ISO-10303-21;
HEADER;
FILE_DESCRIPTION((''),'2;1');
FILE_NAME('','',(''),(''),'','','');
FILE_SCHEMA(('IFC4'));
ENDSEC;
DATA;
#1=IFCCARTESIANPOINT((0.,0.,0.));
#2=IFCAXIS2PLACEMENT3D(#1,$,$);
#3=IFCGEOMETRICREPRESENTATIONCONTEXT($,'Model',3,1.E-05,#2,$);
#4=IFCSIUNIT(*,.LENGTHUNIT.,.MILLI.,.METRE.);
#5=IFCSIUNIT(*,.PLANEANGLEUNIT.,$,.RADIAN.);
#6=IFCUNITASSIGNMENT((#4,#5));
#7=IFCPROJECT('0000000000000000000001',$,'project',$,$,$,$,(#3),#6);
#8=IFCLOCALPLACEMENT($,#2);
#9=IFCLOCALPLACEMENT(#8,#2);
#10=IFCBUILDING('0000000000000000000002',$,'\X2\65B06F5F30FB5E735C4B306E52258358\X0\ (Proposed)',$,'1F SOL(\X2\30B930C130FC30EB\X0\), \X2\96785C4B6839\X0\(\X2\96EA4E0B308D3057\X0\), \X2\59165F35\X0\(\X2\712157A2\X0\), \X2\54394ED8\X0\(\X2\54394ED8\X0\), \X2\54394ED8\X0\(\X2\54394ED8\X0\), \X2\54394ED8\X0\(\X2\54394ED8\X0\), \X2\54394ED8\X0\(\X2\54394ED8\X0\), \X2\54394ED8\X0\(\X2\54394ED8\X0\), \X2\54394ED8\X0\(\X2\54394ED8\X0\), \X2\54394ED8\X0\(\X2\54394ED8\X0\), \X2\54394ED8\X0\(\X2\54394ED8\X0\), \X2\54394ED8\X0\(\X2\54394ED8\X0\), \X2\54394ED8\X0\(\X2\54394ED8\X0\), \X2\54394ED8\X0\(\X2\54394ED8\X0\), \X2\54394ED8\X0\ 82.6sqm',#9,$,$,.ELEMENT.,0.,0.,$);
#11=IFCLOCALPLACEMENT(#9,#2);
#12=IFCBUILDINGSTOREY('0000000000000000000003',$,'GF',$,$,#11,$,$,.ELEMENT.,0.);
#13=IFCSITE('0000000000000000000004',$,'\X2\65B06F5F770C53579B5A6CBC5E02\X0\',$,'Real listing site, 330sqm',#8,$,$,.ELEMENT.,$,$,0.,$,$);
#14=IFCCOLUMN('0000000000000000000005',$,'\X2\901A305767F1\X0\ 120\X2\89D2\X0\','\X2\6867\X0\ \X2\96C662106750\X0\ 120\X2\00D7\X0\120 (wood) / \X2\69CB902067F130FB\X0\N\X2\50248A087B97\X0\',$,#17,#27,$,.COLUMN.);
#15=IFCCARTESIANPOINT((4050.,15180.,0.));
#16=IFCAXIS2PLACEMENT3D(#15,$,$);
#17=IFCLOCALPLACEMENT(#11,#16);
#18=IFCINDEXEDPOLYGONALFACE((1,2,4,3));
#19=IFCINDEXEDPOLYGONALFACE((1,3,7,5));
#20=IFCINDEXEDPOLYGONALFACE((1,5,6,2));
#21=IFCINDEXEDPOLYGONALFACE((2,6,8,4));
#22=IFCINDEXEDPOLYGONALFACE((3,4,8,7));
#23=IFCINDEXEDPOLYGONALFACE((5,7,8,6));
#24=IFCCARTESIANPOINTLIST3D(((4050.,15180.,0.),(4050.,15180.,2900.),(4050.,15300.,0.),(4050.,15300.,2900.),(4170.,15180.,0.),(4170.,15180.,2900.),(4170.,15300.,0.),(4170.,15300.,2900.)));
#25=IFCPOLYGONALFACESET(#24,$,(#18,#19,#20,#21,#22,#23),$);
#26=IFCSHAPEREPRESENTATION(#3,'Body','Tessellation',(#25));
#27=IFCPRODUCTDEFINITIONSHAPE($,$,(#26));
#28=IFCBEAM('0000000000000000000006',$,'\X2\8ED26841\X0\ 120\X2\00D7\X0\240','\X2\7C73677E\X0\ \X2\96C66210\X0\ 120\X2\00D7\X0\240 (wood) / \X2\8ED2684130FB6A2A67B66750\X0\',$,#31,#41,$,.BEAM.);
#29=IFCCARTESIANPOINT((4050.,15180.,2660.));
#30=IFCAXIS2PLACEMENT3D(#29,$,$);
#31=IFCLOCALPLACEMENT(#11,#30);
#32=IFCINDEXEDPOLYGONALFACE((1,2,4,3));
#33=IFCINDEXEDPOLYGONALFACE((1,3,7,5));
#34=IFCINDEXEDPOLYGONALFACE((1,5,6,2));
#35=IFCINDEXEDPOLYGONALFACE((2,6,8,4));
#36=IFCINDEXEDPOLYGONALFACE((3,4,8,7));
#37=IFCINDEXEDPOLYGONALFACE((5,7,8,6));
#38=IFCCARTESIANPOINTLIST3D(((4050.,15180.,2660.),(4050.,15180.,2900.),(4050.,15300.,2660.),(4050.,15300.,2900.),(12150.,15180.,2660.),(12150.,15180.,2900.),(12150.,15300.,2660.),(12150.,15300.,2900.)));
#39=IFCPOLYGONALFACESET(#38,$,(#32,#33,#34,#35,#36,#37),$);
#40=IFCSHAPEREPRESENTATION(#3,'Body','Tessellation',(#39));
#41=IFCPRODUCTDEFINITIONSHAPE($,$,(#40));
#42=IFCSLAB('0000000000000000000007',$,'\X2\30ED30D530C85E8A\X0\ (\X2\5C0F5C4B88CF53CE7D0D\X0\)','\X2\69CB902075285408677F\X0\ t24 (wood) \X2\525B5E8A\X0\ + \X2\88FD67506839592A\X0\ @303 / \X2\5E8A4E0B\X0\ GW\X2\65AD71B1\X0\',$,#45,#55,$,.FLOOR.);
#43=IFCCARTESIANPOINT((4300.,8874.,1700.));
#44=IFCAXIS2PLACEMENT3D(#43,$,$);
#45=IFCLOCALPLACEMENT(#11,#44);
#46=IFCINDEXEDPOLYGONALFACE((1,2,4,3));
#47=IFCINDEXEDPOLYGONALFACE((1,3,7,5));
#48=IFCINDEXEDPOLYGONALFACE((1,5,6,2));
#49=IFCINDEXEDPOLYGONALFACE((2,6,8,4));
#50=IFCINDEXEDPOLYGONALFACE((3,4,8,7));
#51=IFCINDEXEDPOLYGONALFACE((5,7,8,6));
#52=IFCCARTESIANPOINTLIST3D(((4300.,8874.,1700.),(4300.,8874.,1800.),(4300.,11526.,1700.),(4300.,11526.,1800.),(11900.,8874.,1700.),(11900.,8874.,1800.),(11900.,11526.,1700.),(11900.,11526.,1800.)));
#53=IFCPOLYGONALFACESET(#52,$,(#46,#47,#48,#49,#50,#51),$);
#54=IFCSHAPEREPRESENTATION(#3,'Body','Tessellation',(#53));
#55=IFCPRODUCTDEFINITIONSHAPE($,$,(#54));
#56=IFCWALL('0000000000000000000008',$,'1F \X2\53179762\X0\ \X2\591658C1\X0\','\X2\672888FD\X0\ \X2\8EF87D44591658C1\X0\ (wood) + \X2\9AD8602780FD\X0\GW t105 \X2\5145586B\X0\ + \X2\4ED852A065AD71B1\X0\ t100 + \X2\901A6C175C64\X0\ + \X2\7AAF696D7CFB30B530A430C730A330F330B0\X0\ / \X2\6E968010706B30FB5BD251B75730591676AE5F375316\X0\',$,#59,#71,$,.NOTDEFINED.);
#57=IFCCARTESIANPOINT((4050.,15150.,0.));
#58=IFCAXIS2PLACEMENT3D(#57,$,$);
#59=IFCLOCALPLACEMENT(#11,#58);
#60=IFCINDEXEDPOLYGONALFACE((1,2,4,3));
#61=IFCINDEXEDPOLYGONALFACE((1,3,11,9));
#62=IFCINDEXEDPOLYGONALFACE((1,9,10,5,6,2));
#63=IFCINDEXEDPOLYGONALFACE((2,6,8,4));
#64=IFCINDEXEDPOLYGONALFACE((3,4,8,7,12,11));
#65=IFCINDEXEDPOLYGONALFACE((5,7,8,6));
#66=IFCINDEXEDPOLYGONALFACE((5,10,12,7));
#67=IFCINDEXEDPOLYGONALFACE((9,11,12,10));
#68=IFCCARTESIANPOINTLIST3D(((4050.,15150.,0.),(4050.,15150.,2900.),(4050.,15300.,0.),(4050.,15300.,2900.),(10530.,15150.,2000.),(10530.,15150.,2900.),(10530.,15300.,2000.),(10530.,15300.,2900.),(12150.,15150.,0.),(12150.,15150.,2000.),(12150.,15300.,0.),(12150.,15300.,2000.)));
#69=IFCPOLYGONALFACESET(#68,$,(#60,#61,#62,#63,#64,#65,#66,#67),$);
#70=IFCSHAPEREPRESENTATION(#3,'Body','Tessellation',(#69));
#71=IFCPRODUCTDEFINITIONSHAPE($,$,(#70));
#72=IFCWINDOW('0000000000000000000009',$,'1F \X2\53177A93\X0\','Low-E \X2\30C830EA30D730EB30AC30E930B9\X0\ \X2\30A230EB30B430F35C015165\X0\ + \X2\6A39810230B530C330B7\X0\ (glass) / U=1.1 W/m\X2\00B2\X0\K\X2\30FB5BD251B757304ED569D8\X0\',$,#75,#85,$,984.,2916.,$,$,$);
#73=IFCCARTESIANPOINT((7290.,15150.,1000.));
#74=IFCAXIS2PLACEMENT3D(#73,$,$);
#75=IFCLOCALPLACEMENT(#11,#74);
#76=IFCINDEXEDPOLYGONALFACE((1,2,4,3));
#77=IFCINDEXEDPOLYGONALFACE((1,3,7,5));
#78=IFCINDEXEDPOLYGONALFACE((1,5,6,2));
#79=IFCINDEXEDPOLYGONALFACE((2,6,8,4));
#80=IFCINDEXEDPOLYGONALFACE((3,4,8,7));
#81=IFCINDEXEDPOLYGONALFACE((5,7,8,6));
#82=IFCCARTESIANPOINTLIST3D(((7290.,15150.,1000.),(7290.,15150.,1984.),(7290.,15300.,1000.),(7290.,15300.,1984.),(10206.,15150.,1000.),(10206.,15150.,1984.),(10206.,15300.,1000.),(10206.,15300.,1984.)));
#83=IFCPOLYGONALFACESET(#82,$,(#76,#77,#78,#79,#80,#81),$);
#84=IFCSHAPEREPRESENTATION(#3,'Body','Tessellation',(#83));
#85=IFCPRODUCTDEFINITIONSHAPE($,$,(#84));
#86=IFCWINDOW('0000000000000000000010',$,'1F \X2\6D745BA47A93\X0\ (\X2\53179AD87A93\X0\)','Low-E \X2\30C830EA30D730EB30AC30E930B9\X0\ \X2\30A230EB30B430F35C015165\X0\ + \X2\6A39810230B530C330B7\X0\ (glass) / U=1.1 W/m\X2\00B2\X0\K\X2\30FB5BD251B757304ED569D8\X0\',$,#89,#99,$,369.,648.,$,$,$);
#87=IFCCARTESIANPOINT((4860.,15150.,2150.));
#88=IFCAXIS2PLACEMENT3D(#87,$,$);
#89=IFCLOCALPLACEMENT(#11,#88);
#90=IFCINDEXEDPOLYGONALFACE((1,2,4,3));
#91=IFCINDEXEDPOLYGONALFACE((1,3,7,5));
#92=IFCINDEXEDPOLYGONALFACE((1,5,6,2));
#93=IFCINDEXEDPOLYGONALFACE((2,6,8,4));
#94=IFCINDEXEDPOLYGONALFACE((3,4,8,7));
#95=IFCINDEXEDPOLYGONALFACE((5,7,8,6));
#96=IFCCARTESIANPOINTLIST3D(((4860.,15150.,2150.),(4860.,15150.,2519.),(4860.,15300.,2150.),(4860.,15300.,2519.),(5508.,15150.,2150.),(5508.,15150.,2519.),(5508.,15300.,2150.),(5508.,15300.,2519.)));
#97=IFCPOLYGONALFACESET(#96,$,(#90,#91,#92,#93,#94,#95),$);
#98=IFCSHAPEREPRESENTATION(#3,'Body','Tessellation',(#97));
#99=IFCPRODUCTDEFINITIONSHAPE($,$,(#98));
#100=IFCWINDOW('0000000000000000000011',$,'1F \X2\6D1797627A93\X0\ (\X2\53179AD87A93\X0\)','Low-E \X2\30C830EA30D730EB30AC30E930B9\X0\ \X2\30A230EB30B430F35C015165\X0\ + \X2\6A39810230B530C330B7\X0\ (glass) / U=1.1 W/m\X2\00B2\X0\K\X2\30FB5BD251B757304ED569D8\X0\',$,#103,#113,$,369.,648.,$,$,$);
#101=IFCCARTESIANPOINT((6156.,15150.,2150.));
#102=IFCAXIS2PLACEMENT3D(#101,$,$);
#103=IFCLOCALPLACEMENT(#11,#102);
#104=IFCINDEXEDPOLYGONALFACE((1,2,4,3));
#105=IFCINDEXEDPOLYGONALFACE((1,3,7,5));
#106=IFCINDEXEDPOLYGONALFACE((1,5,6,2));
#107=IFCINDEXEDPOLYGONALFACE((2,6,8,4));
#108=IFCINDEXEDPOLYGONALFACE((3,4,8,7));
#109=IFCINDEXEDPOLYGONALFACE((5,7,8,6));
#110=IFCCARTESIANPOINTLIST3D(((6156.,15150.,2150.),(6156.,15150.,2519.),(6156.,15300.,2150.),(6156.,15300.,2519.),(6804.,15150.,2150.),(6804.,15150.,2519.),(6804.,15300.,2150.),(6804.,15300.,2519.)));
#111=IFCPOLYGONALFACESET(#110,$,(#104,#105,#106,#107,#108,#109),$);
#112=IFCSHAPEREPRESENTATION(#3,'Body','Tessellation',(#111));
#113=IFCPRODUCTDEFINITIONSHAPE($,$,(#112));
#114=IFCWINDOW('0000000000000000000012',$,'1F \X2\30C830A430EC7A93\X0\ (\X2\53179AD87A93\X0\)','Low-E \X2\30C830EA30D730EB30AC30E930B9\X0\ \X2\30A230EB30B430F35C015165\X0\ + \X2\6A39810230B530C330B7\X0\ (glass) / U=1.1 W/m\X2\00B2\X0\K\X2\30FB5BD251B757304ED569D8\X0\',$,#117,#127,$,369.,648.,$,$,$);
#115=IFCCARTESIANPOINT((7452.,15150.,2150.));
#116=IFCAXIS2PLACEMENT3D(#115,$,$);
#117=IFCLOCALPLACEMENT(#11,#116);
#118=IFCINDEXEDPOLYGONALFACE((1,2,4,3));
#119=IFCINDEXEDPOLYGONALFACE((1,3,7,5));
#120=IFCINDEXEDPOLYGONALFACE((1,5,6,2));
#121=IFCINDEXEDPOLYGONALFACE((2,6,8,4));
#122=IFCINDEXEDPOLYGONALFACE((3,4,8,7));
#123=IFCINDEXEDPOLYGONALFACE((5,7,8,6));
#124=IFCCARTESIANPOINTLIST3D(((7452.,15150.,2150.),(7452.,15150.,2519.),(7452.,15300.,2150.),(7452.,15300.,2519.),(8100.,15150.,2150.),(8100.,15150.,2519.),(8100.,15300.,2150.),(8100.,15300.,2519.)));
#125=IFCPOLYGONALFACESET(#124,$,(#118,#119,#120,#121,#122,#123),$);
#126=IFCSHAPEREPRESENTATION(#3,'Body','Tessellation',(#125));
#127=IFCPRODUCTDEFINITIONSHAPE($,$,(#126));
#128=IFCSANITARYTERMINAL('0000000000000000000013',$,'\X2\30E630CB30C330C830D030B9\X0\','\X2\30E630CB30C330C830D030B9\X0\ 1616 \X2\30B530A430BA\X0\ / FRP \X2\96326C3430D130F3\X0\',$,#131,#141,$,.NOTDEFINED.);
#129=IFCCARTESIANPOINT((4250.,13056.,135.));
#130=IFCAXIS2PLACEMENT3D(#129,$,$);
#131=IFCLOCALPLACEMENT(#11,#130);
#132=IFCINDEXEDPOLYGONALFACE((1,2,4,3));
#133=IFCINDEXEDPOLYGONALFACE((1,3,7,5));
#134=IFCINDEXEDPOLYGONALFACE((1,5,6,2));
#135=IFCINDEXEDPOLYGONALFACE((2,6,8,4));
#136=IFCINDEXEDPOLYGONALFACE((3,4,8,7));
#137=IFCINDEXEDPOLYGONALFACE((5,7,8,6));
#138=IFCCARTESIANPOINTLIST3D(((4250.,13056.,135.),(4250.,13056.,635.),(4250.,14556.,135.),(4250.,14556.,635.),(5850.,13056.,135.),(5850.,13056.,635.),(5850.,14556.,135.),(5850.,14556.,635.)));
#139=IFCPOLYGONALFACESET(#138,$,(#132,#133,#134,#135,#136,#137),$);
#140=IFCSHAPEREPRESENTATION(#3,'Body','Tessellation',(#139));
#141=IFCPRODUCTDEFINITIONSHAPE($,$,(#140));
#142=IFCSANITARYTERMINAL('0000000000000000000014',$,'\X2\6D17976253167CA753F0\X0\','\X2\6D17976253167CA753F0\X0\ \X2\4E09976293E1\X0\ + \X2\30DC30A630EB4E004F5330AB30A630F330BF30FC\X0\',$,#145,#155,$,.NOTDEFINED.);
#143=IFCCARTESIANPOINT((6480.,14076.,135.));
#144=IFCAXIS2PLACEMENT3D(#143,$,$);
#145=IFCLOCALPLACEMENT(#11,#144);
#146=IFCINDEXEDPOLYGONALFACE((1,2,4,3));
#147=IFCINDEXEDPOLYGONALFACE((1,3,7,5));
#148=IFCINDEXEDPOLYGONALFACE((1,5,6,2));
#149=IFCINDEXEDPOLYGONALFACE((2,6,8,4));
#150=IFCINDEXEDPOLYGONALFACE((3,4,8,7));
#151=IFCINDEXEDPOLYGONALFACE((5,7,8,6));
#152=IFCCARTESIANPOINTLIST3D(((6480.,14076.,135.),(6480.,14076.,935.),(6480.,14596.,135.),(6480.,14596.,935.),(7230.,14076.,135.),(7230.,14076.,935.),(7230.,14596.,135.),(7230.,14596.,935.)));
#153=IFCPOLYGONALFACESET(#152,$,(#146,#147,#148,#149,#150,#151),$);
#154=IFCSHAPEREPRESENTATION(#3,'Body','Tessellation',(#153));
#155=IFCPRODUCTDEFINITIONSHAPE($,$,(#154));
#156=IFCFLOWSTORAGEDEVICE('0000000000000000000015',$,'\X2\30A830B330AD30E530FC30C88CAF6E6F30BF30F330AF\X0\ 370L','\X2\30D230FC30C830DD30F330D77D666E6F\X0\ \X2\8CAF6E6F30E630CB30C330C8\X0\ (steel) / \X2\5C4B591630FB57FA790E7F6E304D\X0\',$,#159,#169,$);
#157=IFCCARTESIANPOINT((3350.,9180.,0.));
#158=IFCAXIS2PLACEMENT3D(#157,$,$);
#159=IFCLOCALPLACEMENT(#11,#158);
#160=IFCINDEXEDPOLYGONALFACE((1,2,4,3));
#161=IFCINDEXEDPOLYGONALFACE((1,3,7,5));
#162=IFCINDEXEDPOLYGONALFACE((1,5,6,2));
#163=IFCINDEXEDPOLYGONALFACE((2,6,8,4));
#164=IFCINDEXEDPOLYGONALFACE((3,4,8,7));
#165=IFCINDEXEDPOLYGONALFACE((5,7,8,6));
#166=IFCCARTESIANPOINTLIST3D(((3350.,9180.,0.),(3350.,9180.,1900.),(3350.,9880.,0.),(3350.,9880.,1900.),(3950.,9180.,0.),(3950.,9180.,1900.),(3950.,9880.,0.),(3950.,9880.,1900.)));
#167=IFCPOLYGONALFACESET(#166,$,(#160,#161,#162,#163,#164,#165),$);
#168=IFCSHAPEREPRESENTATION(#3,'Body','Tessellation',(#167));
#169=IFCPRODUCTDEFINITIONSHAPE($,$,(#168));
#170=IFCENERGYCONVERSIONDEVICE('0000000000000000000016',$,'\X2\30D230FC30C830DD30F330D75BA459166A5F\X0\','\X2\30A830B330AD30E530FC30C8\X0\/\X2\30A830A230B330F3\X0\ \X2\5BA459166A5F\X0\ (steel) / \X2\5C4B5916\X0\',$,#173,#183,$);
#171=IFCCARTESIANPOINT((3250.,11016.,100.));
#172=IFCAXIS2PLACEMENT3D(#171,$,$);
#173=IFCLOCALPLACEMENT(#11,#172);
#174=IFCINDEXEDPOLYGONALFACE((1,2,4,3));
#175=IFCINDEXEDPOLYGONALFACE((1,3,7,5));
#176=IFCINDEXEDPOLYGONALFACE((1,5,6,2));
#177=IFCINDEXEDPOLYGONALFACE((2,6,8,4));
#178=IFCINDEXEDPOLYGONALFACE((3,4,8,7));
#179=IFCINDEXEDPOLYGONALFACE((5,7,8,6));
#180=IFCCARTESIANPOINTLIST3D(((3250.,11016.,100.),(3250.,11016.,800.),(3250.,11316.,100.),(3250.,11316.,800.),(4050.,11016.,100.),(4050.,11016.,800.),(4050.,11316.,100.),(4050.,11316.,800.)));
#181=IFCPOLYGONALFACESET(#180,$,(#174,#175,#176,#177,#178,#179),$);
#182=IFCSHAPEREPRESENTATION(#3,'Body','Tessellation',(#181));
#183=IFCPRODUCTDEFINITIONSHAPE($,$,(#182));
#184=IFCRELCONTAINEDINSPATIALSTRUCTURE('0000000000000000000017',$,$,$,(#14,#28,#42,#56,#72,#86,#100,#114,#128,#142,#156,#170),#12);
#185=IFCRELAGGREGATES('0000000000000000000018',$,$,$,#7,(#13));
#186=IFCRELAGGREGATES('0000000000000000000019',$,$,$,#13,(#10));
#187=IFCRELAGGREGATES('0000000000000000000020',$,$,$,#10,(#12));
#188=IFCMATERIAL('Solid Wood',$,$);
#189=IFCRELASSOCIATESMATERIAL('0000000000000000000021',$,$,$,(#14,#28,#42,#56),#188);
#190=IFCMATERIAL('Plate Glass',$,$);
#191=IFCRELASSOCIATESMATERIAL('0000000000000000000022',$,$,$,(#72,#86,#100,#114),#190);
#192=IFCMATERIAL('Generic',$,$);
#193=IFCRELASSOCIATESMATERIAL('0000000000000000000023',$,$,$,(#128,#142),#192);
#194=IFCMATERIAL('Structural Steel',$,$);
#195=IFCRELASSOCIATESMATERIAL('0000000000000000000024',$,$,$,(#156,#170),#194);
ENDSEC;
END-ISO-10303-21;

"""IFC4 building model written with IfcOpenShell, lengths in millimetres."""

from ifc_helpers import new_model, si_unit, frame, frame_2d, origin, place, context, project, spatial, rectangle, extrude, material, element, fill, save


model = new_model("IFC4")

# Units and contexts
model_context = context("Model", 3, precision=1e-05, world=origin())
ifc_project = project(units=[si_unit("LENGTHUNIT", "METRE", prefix="MILLI"), si_unit("PLANEANGLEUNIT", "RADIAN")], contexts=[model_context])

# Site, building, storey
site_placement = place(None, origin())
site = spatial("IfcSite", under=ifc_project, at=site_placement, Name="新潟県南魚沼市", ObjectType="Real listing site, 330sqm", CompositionType="ELEMENT", RefElevation=0.0)
building_placement = place(site_placement, origin())
building = spatial("IfcBuilding", under=site, at=building_placement, Name="新潟・平屋の別荘 (Proposed)", ObjectType="1F SOL(スチール), 陸屋根(雪下ろし), 外張(無垢), 吹付(吹付), 吹付(吹付), 吹付(吹付), 吹付(吹付), 吹付(吹付), 吹付(吹付), 吹付(吹付), 吹付(吹付), 吹付(吹付), 吹付(吹付), 吹付(吹付), 吹付 82.6sqm", CompositionType="ELEMENT", ElevationOfRefHeight=0.0, ElevationOfTerrain=0.0)
storey_placement = place(building_placement, origin())
storey = spatial("IfcBuildingStorey", under=building, at=storey_placement, Name="GF", CompositionType="ELEMENT", Elevation=0.0)

# Column
ifc_material_1 = material(Name="Solid Wood")
column_1_placement = place(storey_placement, frame((4050.0, 15180.0, 0.0)))
element("IfcColumn", 1, at=column_1_placement, inside=storey, material=ifc_material_1, Name="通し柱 120角", Description="桧 集成材 120×120 (wood) / 構造柱・N値計算", PredefinedType="COLUMN", context=model_context, shape_type="SweptSolid", body=[
    extrude(rectangle(XDim=120.0, YDim=120.0, at=frame_2d((60.0, 60.0))), frame((4050.0, 15180.0, 0.0)), (0.0, 0.0, 1.0), 2900.0),
])

# Beam
beam_1_placement = place(storey_placement, frame((4050.0, 15180.0, 2660.0)))
element("IfcBeam", 2, at=beam_1_placement, inside=storey, material=ifc_material_1, Name="軒桁 120×240", Description="米松 集成 120×240 (wood) / 軒桁・横架材", PredefinedType="BEAM", context=model_context, shape_type="SweptSolid", body=[
    extrude(rectangle(XDim=8100.0, YDim=120.0, at=frame_2d((4050.0, 60.0))), frame((4050.0, 15180.0, 2660.0)), (0.0, 0.0, 1.0), 240.0),
])

# Slab
slab_placement = place(storey_placement, frame((4300.0, 8874.0, 1700.0)))
element("IfcSlab", 3, at=slab_placement, inside=storey, material=ifc_material_1, Name="ロフト床 (小屋裏収納)", Description="構造用合板 t24 (wood) 剛床 + 製材根太 @303 / 床下 GW断熱", PredefinedType="FLOOR", context=model_context, shape_type="SweptSolid", body=[
    extrude(rectangle(XDim=7600.0, YDim=2652.0, at=frame_2d((3800.0, 1326.0))), frame((4300.0, 8874.0, 1700.0)), (0.0, 0.0, 1.0), 100.0),
])

# Wall, openings, windows
wall_1_placement = place(storey_placement, frame((4050.0, 15150.0, 0.0)))
wall_1 = element("IfcWall", 4, at=wall_1_placement, inside=storey, material=ifc_material_1, Name="1F 北面 外壁", Description="木製 軸組外壁 (wood) + 高性能GW t105 充填 + 付加断熱 t100 + 通気層 + 窯業系サイディング / 準耐火・寒冷地外皮強化", PredefinedType="NOTDEFINED", context=model_context, shape_type="SweptSolid", body=[
    extrude(rectangle(XDim=8100.0, YDim=150.0, at=frame_2d((4050.0, 75.0))), frame((4050.0, 15150.0, 0.0)), (0.0, 0.0, 1.0), 2900.0),
])
opening_1_placement = place(storey_placement, frame((7290.0, 15150.0, 1000.0)))
opening_1 = element("IfcOpeningElement", 5, at=opening_1_placement, cuts=wall_1, PredefinedType="NOTDEFINED", context=model_context, shape_type="SweptSolid", body=[
    extrude(rectangle(XDim=2916.0, YDim=150.0, at=frame_2d((1458.0, 75.0))), frame((7290.0, 15150.0, 1000.0)), (0.0, 0.0, 1.0), 984.0),
])
opening_2_placement = place(storey_placement, frame((4860.0, 15150.0, 2150.0)))
opening_2 = element("IfcOpeningElement", 6, at=opening_2_placement, cuts=wall_1, PredefinedType="NOTDEFINED", context=model_context, shape_type="SweptSolid", body=[
    extrude(rectangle(XDim=648.0, YDim=150.0, at=frame_2d((324.0, 75.0))), frame((4860.0, 15150.0, 2150.0)), (0.0, 0.0, 1.0), 369.0),
])
opening_3_placement = place(storey_placement, frame((6156.0, 15150.0, 2150.0)))
opening_3 = element("IfcOpeningElement", 7, at=opening_3_placement, cuts=wall_1, PredefinedType="NOTDEFINED", context=model_context, shape_type="SweptSolid", body=[
    extrude(rectangle(XDim=648.0, YDim=150.0, at=frame_2d((324.0, 75.0))), frame((6156.0, 15150.0, 2150.0)), (0.0, 0.0, 1.0), 369.0),
])
opening_4_placement = place(storey_placement, frame((7452.0, 15150.0, 2150.0)))
opening_4 = element("IfcOpeningElement", 8, at=opening_4_placement, cuts=wall_1, PredefinedType="NOTDEFINED", context=model_context, shape_type="SweptSolid", body=[
    extrude(rectangle(XDim=648.0, YDim=150.0, at=frame_2d((324.0, 75.0))), frame((7452.0, 15150.0, 2150.0)), (0.0, 0.0, 1.0), 369.0),
])
ifc_material_2 = material(Name="Plate Glass")
window_1_placement = place(storey_placement, frame((7290.0, 15150.0, 1000.0)))
window_1 = element("IfcWindow", 9, at=window_1_placement, inside=storey, material=ifc_material_2, Name="1F 北窓", Description="Low-E トリプルガラス アルゴン封入 + 樹脂サッシ (glass) / U=1.1 W/m²K・寒冷地仕様", OverallHeight=984.0, OverallWidth=2916.0, context=model_context, shape_type="SweptSolid", body=[
    extrude(rectangle(XDim=2916.0, YDim=150.0, at=frame_2d((1458.0, 75.0))), frame((7290.0, 15150.0, 1000.0)), (0.0, 0.0, 1.0), 984.0),
])
fill(opening_1, window_1)
window_2_placement = place(storey_placement, frame((4860.0, 15150.0, 2150.0)))
window_2 = element("IfcWindow", 10, at=window_2_placement, inside=storey, material=ifc_material_2, Name="1F 浴室窓 (北高窓)", Description="Low-E トリプルガラス アルゴン封入 + 樹脂サッシ (glass) / U=1.1 W/m²K・寒冷地仕様", OverallHeight=369.0, OverallWidth=648.0, context=model_context, shape_type="SweptSolid", body=[
    extrude(rectangle(XDim=648.0, YDim=150.0, at=frame_2d((324.0, 75.0))), frame((4860.0, 15150.0, 2150.0)), (0.0, 0.0, 1.0), 369.0),
])
fill(opening_2, window_2)
window_3_placement = place(storey_placement, frame((6156.0, 15150.0, 2150.0)))
window_3 = element("IfcWindow", 11, at=window_3_placement, inside=storey, material=ifc_material_2, Name="1F 洗面窓 (北高窓)", Description="Low-E トリプルガラス アルゴン封入 + 樹脂サッシ (glass) / U=1.1 W/m²K・寒冷地仕様", OverallHeight=369.0, OverallWidth=648.0, context=model_context, shape_type="SweptSolid", body=[
    extrude(rectangle(XDim=648.0, YDim=150.0, at=frame_2d((324.0, 75.0))), frame((6156.0, 15150.0, 2150.0)), (0.0, 0.0, 1.0), 369.0),
])
fill(opening_3, window_3)
window_4_placement = place(storey_placement, frame((7452.0, 15150.0, 2150.0)))
window_4 = element("IfcWindow", 12, at=window_4_placement, inside=storey, material=ifc_material_2, Name="1F トイレ窓 (北高窓)", Description="Low-E トリプルガラス アルゴン封入 + 樹脂サッシ (glass) / U=1.1 W/m²K・寒冷地仕様", OverallHeight=369.0, OverallWidth=648.0, context=model_context, shape_type="SweptSolid", body=[
    extrude(rectangle(XDim=648.0, YDim=150.0, at=frame_2d((324.0, 75.0))), frame((7452.0, 15150.0, 2150.0)), (0.0, 0.0, 1.0), 369.0),
])
fill(opening_4, window_4)

# Sanitary terminals
ifc_material_3 = material(Name="Generic")
sanitary_terminal_1_placement = place(storey_placement, frame((4250.0, 13056.0, 135.0)))
element("IfcSanitaryTerminal", 13, at=sanitary_terminal_1_placement, inside=storey, material=ifc_material_3, Name="ユニットバス", Description="ユニットバス 1616 サイズ / FRP 防水パン", PredefinedType="NOTDEFINED", context=model_context, shape_type="SweptSolid", body=[
    extrude(rectangle(XDim=1600.0, YDim=1500.0, at=frame_2d((800.0, 750.0))), frame((4250.0, 13056.0, 135.0)), (0.0, 0.0, 1.0), 500.0),
])
sanitary_terminal_2_placement = place(storey_placement, frame((6480.0, 14076.0, 135.0)))
element("IfcSanitaryTerminal", 14, at=sanitary_terminal_2_placement, inside=storey, material=ifc_material_3, Name="洗面化粧台", Description="洗面化粧台 三面鏡 + ボウル一体カウンター", PredefinedType="NOTDEFINED", context=model_context, shape_type="SweptSolid", body=[
    extrude(rectangle(XDim=750.0, YDim=520.0, at=frame_2d((375.0, 260.0))), frame((6480.0, 14076.0, 135.0)), (0.0, 0.0, 1.0), 800.0),
])

# Flow storage device
ifc_material_4 = material(Name="Structural Steel")
flow_storage_device_placement = place(storey_placement, frame((3350.0, 9180.0, 0.0)))
element("IfcFlowStorageDevice", 15, at=flow_storage_device_placement, inside=storey, material=ifc_material_4, Name="エコキュート貯湯タンク 370L", Description="ヒートポンプ給湯 貯湯ユニット (steel) / 屋外・基礎置き", context=model_context, shape_type="SweptSolid", body=[
    extrude(rectangle(XDim=600.0, YDim=700.0, at=frame_2d((300.0, 350.0))), frame((3350.0, 9180.0, 0.0)), (0.0, 0.0, 1.0), 1900.0),
])

# Energy conversion device
energy_conversion_device_placement = place(storey_placement, frame((3250.0, 11016.0, 100.0)))
element("IfcEnergyConversionDevice", 16, at=energy_conversion_device_placement, inside=storey, material=ifc_material_4, Name="ヒートポンプ室外機", Description="エコキュート/エアコン 室外機 (steel) / 屋外", context=model_context, shape_type="SweptSolid", body=[
    extrude(rectangle(XDim=800.0, YDim=300.0, at=frame_2d((400.0, 150.0))), frame((3250.0, 11016.0, 100.0)), (0.0, 0.0, 1.0), 700.0),
])

save(model, "model.ifc")
